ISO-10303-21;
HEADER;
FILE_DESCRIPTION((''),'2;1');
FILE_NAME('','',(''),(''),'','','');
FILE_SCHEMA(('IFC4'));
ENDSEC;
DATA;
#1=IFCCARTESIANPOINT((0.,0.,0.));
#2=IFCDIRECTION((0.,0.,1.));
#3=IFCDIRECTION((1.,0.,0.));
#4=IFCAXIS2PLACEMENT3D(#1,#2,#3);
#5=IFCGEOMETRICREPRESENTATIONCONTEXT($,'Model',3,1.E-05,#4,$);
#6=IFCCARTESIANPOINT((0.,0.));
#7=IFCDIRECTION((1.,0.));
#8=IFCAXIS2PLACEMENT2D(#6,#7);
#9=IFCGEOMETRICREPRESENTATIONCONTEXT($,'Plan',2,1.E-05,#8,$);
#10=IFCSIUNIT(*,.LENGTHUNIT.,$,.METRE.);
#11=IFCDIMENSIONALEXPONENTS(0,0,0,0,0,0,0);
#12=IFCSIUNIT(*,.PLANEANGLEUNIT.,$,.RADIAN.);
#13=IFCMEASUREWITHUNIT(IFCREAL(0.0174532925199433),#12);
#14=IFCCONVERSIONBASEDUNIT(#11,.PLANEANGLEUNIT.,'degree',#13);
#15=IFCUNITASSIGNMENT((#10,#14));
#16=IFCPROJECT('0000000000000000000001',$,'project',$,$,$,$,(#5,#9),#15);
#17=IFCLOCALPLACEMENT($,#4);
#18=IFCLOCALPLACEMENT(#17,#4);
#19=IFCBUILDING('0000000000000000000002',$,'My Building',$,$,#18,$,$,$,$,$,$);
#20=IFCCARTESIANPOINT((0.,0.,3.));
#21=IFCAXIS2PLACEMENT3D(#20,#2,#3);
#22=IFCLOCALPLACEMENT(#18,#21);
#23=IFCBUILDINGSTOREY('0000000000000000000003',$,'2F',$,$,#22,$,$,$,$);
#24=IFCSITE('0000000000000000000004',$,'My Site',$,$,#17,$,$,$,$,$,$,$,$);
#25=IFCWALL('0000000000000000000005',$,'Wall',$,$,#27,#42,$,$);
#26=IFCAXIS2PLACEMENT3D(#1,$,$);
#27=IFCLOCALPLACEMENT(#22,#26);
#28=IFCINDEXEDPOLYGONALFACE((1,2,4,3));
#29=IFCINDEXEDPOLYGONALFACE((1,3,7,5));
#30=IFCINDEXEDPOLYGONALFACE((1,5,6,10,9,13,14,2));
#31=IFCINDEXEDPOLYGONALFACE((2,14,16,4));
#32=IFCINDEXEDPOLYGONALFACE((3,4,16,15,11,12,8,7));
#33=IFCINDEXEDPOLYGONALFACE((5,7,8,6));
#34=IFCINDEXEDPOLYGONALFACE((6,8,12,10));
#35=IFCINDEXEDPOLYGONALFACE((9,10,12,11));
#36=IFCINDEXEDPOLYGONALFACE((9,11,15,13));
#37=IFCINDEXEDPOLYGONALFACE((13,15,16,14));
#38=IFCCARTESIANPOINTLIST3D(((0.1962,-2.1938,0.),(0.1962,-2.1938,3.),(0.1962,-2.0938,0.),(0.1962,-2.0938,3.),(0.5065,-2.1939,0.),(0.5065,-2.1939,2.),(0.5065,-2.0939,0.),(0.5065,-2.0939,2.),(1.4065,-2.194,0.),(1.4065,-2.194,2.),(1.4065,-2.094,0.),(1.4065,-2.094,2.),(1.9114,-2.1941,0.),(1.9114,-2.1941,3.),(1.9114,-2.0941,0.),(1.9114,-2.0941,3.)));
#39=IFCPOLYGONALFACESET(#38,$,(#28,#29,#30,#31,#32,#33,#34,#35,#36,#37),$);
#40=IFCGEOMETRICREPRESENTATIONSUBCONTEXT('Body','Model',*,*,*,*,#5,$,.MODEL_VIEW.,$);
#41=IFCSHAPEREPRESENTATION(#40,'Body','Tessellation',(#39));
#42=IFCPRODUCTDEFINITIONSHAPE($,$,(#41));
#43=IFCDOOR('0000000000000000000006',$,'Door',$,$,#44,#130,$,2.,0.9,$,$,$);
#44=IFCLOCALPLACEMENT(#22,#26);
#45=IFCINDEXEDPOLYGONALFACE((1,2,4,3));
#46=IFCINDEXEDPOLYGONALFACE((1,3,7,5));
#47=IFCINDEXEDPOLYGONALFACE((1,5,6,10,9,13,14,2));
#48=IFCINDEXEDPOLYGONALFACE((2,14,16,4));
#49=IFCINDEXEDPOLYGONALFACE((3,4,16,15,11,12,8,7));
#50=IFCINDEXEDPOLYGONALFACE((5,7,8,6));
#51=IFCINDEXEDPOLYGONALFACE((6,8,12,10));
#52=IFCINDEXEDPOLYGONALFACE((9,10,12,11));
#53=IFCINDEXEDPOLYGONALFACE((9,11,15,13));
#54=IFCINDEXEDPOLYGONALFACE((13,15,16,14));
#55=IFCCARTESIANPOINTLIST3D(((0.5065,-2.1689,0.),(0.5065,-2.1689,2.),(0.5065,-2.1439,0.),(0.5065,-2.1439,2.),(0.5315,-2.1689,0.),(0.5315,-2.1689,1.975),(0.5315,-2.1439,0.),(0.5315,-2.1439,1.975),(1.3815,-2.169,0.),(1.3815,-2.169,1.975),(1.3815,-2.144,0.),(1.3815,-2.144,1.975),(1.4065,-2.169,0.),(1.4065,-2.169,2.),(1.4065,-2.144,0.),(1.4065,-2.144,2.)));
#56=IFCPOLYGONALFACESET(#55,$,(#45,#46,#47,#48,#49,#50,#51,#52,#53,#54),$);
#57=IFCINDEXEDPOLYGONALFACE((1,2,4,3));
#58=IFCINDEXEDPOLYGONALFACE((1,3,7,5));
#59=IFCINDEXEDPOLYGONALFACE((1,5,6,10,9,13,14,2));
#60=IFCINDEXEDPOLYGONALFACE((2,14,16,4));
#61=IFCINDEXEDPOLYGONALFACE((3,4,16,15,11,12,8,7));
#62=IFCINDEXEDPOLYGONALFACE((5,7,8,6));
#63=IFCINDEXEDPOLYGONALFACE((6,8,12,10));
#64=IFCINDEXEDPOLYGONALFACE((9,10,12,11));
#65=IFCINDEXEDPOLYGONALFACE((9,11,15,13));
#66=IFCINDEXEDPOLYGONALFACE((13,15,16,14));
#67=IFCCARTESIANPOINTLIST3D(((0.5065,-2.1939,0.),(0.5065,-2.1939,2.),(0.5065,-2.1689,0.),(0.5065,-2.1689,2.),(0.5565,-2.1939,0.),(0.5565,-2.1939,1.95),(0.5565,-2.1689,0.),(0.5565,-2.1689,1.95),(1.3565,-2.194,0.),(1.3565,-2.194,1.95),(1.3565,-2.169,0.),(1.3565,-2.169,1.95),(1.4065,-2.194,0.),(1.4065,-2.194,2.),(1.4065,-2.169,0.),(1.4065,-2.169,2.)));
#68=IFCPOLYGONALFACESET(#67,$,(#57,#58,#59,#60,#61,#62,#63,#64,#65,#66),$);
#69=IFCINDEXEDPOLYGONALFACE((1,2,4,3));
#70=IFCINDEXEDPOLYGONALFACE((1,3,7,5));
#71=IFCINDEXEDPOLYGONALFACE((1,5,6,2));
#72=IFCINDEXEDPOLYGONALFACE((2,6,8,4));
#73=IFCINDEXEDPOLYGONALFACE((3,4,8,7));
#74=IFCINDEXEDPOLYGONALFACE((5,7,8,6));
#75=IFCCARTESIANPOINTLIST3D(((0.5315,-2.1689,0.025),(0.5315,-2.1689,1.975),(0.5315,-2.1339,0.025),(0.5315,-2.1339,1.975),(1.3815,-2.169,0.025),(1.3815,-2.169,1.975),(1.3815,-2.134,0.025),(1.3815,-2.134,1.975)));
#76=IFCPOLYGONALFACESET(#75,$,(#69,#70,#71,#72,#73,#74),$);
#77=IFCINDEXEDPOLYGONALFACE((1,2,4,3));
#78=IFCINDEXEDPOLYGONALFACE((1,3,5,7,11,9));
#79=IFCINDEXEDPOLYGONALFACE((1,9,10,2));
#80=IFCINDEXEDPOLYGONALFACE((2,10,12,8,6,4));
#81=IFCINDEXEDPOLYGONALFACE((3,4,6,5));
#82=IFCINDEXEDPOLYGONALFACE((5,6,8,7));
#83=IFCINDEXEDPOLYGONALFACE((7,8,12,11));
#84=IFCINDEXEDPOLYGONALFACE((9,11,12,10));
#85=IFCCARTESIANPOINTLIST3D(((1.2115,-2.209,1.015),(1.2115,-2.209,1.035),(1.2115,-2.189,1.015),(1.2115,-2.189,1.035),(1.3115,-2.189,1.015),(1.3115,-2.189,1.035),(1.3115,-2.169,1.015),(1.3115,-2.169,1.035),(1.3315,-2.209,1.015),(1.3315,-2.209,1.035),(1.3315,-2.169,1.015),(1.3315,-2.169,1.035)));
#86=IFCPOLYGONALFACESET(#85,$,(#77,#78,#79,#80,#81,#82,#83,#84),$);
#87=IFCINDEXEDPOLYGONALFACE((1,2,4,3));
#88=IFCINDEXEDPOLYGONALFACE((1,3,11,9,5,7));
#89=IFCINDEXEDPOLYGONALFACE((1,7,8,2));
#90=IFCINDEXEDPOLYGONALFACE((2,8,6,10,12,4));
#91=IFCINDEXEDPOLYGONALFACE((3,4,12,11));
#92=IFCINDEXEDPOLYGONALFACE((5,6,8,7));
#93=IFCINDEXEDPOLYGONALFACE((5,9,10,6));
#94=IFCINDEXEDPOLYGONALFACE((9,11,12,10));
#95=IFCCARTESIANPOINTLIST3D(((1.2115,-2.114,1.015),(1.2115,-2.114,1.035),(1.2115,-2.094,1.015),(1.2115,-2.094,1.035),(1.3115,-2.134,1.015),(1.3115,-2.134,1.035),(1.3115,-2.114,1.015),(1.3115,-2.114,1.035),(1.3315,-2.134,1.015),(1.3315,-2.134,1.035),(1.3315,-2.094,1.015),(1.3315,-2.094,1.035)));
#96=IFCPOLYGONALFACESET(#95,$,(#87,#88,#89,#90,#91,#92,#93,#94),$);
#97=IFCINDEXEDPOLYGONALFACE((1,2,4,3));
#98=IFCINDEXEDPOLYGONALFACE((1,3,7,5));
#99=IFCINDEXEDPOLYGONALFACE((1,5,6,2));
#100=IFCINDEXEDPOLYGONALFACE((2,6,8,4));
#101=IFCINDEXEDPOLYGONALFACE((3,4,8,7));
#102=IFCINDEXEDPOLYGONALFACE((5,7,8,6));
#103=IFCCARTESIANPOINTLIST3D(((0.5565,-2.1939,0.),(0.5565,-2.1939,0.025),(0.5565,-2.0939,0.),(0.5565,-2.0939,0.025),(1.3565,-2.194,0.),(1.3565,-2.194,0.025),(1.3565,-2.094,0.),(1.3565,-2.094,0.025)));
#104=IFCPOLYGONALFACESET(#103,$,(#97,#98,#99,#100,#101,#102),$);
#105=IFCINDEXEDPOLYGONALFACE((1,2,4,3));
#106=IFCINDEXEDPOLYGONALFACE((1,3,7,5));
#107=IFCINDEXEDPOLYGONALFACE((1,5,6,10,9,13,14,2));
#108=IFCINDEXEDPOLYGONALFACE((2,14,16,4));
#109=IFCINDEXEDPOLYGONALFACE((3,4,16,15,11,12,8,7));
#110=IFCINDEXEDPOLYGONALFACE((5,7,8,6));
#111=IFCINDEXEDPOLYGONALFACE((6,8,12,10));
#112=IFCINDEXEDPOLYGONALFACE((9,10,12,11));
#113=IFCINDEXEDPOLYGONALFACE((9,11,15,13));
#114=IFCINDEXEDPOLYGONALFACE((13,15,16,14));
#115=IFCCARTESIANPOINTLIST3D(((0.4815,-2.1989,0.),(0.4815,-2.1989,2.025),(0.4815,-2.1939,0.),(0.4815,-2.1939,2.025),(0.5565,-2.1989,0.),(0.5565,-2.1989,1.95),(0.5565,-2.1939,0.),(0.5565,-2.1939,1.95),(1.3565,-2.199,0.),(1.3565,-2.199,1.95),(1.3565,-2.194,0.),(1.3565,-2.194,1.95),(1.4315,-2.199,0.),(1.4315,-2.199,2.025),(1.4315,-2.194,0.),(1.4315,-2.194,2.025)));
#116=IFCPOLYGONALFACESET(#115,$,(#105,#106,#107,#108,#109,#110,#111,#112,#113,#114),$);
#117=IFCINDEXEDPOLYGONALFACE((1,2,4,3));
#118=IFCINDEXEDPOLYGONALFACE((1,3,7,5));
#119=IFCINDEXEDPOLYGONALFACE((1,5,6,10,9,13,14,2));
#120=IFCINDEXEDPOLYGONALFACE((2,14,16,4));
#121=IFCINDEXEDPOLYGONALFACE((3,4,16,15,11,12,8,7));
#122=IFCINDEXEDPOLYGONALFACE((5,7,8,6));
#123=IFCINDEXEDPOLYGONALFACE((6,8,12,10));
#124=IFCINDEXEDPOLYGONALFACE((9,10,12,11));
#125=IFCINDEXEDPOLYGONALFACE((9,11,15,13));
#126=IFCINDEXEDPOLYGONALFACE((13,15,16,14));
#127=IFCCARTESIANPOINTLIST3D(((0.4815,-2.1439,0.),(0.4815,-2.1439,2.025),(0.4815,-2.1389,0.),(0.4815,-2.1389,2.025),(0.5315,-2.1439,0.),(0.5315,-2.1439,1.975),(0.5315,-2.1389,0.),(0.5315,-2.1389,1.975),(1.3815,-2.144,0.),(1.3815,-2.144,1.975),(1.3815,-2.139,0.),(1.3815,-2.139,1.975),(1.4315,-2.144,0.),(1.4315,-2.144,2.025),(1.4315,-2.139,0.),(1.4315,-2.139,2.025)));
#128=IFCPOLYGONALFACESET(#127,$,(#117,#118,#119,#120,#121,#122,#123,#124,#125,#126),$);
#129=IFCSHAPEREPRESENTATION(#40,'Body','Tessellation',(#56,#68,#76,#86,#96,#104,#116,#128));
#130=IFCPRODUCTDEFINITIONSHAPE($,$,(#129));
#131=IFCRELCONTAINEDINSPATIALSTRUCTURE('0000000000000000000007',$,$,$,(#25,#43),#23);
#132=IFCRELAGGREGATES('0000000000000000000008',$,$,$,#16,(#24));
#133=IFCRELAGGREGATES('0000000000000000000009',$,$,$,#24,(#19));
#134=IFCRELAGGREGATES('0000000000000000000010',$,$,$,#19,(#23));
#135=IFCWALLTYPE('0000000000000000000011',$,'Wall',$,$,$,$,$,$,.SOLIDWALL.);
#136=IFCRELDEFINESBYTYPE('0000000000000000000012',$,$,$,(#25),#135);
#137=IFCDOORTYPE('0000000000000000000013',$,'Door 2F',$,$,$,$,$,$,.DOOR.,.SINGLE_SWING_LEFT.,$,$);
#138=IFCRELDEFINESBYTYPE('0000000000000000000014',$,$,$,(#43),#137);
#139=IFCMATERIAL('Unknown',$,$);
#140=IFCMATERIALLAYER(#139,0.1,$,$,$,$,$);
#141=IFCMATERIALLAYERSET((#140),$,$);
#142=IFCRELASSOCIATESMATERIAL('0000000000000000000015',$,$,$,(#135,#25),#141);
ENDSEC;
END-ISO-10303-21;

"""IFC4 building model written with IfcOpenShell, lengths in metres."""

from ifc_helpers import new_model, entity, si_unit, converted_unit, frame, origin_with_axes, origin_2d_with_axis, place, context, subcontext, project, spatial, line, indexed_curve, outline, extrude, shape, source, transform, mapped, material, layer, layer_set, layer_usage, type_object, type_shapes, element, fill, save


model = new_model("IFC4")

# Units and contexts
model_context = context("Model", 3, precision=1e-05, world=origin_with_axes())
plan_context = context("Plan", 2, precision=1e-05, world=origin_2d_with_axis())
body_context_1 = subcontext(model_context, "Body", "Model", "MODEL_VIEW")
body_context_2 = subcontext(plan_context, "Body", "Plan", "PLAN_VIEW")
ifc_project = project(units=[si_unit("LENGTHUNIT", "METRE"), converted_unit("PLANEANGLEUNIT", "degree", entity("IfcReal", 0.0174532925199433), si_unit("PLANEANGLEUNIT", "RADIAN"), dimensions=[0, 0, 0, 0, 0, 0, 0])], contexts=[model_context, plan_context])

# Site, building, storey
site_placement = place(None, origin_with_axes())
site = spatial("IfcSite", under=ifc_project, at=site_placement, Name="My Site")
building_placement = place(site_placement, origin_with_axes())
building = spatial("IfcBuilding", under=site, at=building_placement, Name="My Building")
storey_placement = place(building_placement, frame((0.0, 0.0, 3.0), z_axis=(0.0, 0.0, 1.0), x_axis=(1.0, 0.0, 0.0)))
storey = spatial("IfcBuildingStorey", under=building, at=storey_placement, Name="2F")

# Shared definitions
ifc_material = material(Name="Unknown")

# Shared definitions
ifc_layer_1 = layer(ifc_material, 0.1)
ifc_layer_set_1 = layer_set([ifc_layer_1])
wall_type = type_object("IfcWallType", Name="Wall", PredefinedType="SOLIDWALL", material=ifc_layer_set_1)

# Wall, opening, door
ifc_layer_usage_1 = layer_usage(ifc_layer_set_1, "AXIS2", "POSITIVE", 0.0)
wall_1_placement = place(storey_placement, frame((0.1962, -2.1938, 0.0), z_axis=(0.0, 0.0, 1.0), x_axis=(1.0, -0.00013, 0.0)))
wall_1 = element("IfcWall", 1, at=wall_1_placement, inside=storey, type_object=wall_type, material=ifc_layer_usage_1, Name="Wall", context=body_context_1, shape_type="SweptSolid", body=[
    extrude(outline(indexed_curve([(0.0, 0.0), (0.0, 0.1), (1.7152, 0.1), (1.7152, 0.0)], segments=[line(1, 2, 3, 4, 1)])), origin_with_axes(), (0.0, 0.0, 1.0), 3.0),
])
shared_shape_1 = source(origin_with_axes(), body_context_1, "Body", "SweptSolid", [
    extrude(outline(indexed_curve([(0.0, 0.0), (0.9, 0.0), (0.9, 2.0), (0.0, 2.0)], segments=[line(1, 2, 3, 4, 1)])), frame((0.0, -0.6, 0.0), z_axis=(0.0, -1.0, 0.0), x_axis=(1.0, 0.0, 0.0)), (0.0, 0.0, -1.0), 1.2),
])
opening_1_placement = place(wall_1_placement, frame((0.3103, 0.0, 0.0), z_axis=(0.0, 0.0, 1.0), x_axis=(1.0, 0.0, 0.0)))
opening_1 = element("IfcOpeningElement", 2, at=opening_1_placement, cuts=wall_1, PredefinedType="OPENING", context=body_context_1, shape_type="MappedRepresentation", body=[
    mapped(shared_shape_1, transform((0.0, 0.0, 0.0), x_axis=(1.0, 0.0, 0.0), y_axis=(0.0, 1.0, 0.0), z_axis=(0.0, 0.0, 1.0), scale=1.0)),
])
door_type_1 = type_object("IfcDoorType", Name="Door 2F", OperationType="SINGLE_SWING_LEFT", PredefinedType="DOOR")
shared_shape_2 = source(origin_with_axes(), body_context_1, "Body", "SweptSolid", [
    extrude(outline(indexed_curve([(0.0, 0.0), (0.0, 2.0), (0.9, 2.0), (0.9, 0.0), (0.875, 0.0), (0.875, 1.975), (0.025, 1.975), (0.025, 0.0)], segments=[line(1, 2, 3, 4, 5, 6, 7, 8, 1)])), frame((0.0, 0.025, 0.0), z_axis=(0.0, -1.0, 0.0), x_axis=(1.0, 0.0, 0.0)), (0.0, 0.0, -1.0), 0.025),
    extrude(outline(indexed_curve([(0.0, 0.0), (0.0, 2.0), (0.9, 2.0), (0.9, 0.0), (0.85, 0.0), (0.85, 1.95), (0.05, 1.95), (0.05, 0.0)], segments=[line(1, 2, 3, 4, 5, 6, 7, 8, 1)])), frame((0.0, 0.0, 0.0), z_axis=(0.0, -1.0, 0.0), x_axis=(1.0, 0.0, 0.0)), (0.0, 0.0, -1.0), 0.025),
    extrude(outline(indexed_curve([(0.0, 0.0), (0.85, 0.0), (0.85, 0.035), (0.0, 0.035)], segments=[line(1, 2, 3, 4, 1)])), frame((0.025, 0.025, 0.025), z_axis=(0.0, 0.0, 1.0), x_axis=(1.0, 0.0, 0.0)), (0.0, 0.0, 1.0), 1.95),
    extrude(outline(indexed_curve([(0.0, 0.0), (0.0, -0.04), (-0.12, -0.04), (-0.12, -0.02), (-0.02, -0.02), (-0.02, 0.0)], segments=[line(1, 2, 3, 4, 5, 6, 1)])), frame((0.825, 0.025, 1.015), z_axis=(0.0, 0.0, 1.0), x_axis=(1.0, 0.0, 0.0)), (0.0, 0.0, 1.0), 0.02),
    extrude(outline(indexed_curve([(0.0, 0.0), (0.0, 0.04), (-0.12, 0.04), (-0.12, 0.02), (-0.02, 0.02), (-0.02, 0.0)], segments=[line(1, 2, 3, 4, 5, 6, 1)])), frame((0.825, 0.06, 1.015), z_axis=(0.0, 0.0, 1.0), x_axis=(1.0, 0.0, 0.0)), (0.0, 0.0, 1.0), 0.02),
    extrude(outline(indexed_curve([(0.0, 0.0), (0.8, 0.0), (0.8, 0.1), (0.0, 0.1)], segments=[line(1, 2, 3, 4, 1)])), frame((0.05, 0.0, 0.0), z_axis=(0.0, 0.0, 1.0), x_axis=(1.0, 0.0, 0.0)), (0.0, 0.0, 1.0), 0.025),
    extrude(outline(indexed_curve([(0.0, 0.0), (0.0, 2.025), (0.95, 2.025), (0.95, 0.0), (0.875, 0.0), (0.875, 1.95), (0.075, 1.95), (0.075, 0.0)], segments=[line(1, 2, 3, 4, 5, 6, 7, 8, 1)])), frame((-0.025, -0.005, 0.0), z_axis=(0.0, -1.0, 0.0), x_axis=(1.0, 0.0, 0.0)), (0.0, 0.0, -1.0), 0.005),
    extrude(outline(indexed_curve([(0.0, 0.0), (0.0, 2.025), (0.95, 2.025), (0.95, 0.0), (0.9, 0.0), (0.9, 1.975), (0.05, 1.975), (0.05, 0.0)], segments=[line(1, 2, 3, 4, 5, 6, 7, 8, 1)])), frame((-0.025, 0.05, 0.0), z_axis=(0.0, -1.0, 0.0), x_axis=(1.0, 0.0, 0.0)), (0.0, 0.0, -1.0), 0.005),
])
shared_shape_3 = source(origin_with_axes(), body_context_2, "Body", "Curve2D", [
    entity("IfcIndexedPolyCurve", entity("IfcCartesianPointList2D", [[0.0, 0.0], [0.0, 0.05], [0.025, 0.05], [0.025, 0.025], [0.05, 0.025], [0.05, 0.0]]), [entity("IfcLineIndex", [1, 2, 3, 4, 5, 6, 1])]),
    entity("IfcIndexedPolyCurve", entity("IfcCartesianPointList2D", [[0.9, 0.0], [0.9, 0.05], [0.875, 0.05], [0.875, 0.025], [0.85, 0.025], [0.85, 0.0]]), [entity("IfcLineIndex", [1, 2, 3, 4, 5, 6, 1])]),
    entity("IfcTrimmedCurve", entity("IfcEllipse", entity("IfcAxis2Placement2D", entity("IfcCartesianPoint", [0.06, 0.05]), entity("IfcDirection", [1.0, 0.0])), 0.815, 0.85), [entity("IfcCartesianPoint", [0.875, 0.05])], [entity("IfcCartesianPoint", [0.06, 0.9])], True, "CARTESIAN"),
    entity("IfcIndexedPolyCurve", entity("IfcCartesianPointList2D", [[0.025, 0.05], [0.06, 0.05], [0.06, 0.9], [0.025, 0.9]]), [entity("IfcLineIndex", [1, 2, 3, 4, 1])]),
])
type_shapes(door_type_1, [shared_shape_2, shared_shape_3])
door_1_placement = place(opening_1_placement, frame((0.0, 0.0, 0.0), z_axis=(0.0, 0.0, 1.0), x_axis=(1.0, 0.0, 0.0)))
door_1 = element("IfcDoor", 3, at=door_1_placement, inside=storey, type_object=door_type_1, Name="Door", OverallHeight=2.0, OverallWidth=0.9, shapes=[
    shape(body_context_1, "Body", "MappedRepresentation", [mapped(shared_shape_2, transform((0.0, 0.0, 0.0), x_axis=(1.0, 0.0, 0.0), y_axis=(0.0, 1.0, 0.0), z_axis=(0.0, 0.0, 1.0), scale=1.0))]),
    shape(body_context_2, "Body", "MappedRepresentation", [mapped(shared_shape_3, transform((0.0, 0.0, 0.0), x_axis=(1.0, 0.0, 0.0), y_axis=(0.0, 1.0, 0.0), z_axis=(0.0, 0.0, 1.0), scale=1.0))]),
])
fill(opening_1, door_1)

save(model, "model.ifc")
